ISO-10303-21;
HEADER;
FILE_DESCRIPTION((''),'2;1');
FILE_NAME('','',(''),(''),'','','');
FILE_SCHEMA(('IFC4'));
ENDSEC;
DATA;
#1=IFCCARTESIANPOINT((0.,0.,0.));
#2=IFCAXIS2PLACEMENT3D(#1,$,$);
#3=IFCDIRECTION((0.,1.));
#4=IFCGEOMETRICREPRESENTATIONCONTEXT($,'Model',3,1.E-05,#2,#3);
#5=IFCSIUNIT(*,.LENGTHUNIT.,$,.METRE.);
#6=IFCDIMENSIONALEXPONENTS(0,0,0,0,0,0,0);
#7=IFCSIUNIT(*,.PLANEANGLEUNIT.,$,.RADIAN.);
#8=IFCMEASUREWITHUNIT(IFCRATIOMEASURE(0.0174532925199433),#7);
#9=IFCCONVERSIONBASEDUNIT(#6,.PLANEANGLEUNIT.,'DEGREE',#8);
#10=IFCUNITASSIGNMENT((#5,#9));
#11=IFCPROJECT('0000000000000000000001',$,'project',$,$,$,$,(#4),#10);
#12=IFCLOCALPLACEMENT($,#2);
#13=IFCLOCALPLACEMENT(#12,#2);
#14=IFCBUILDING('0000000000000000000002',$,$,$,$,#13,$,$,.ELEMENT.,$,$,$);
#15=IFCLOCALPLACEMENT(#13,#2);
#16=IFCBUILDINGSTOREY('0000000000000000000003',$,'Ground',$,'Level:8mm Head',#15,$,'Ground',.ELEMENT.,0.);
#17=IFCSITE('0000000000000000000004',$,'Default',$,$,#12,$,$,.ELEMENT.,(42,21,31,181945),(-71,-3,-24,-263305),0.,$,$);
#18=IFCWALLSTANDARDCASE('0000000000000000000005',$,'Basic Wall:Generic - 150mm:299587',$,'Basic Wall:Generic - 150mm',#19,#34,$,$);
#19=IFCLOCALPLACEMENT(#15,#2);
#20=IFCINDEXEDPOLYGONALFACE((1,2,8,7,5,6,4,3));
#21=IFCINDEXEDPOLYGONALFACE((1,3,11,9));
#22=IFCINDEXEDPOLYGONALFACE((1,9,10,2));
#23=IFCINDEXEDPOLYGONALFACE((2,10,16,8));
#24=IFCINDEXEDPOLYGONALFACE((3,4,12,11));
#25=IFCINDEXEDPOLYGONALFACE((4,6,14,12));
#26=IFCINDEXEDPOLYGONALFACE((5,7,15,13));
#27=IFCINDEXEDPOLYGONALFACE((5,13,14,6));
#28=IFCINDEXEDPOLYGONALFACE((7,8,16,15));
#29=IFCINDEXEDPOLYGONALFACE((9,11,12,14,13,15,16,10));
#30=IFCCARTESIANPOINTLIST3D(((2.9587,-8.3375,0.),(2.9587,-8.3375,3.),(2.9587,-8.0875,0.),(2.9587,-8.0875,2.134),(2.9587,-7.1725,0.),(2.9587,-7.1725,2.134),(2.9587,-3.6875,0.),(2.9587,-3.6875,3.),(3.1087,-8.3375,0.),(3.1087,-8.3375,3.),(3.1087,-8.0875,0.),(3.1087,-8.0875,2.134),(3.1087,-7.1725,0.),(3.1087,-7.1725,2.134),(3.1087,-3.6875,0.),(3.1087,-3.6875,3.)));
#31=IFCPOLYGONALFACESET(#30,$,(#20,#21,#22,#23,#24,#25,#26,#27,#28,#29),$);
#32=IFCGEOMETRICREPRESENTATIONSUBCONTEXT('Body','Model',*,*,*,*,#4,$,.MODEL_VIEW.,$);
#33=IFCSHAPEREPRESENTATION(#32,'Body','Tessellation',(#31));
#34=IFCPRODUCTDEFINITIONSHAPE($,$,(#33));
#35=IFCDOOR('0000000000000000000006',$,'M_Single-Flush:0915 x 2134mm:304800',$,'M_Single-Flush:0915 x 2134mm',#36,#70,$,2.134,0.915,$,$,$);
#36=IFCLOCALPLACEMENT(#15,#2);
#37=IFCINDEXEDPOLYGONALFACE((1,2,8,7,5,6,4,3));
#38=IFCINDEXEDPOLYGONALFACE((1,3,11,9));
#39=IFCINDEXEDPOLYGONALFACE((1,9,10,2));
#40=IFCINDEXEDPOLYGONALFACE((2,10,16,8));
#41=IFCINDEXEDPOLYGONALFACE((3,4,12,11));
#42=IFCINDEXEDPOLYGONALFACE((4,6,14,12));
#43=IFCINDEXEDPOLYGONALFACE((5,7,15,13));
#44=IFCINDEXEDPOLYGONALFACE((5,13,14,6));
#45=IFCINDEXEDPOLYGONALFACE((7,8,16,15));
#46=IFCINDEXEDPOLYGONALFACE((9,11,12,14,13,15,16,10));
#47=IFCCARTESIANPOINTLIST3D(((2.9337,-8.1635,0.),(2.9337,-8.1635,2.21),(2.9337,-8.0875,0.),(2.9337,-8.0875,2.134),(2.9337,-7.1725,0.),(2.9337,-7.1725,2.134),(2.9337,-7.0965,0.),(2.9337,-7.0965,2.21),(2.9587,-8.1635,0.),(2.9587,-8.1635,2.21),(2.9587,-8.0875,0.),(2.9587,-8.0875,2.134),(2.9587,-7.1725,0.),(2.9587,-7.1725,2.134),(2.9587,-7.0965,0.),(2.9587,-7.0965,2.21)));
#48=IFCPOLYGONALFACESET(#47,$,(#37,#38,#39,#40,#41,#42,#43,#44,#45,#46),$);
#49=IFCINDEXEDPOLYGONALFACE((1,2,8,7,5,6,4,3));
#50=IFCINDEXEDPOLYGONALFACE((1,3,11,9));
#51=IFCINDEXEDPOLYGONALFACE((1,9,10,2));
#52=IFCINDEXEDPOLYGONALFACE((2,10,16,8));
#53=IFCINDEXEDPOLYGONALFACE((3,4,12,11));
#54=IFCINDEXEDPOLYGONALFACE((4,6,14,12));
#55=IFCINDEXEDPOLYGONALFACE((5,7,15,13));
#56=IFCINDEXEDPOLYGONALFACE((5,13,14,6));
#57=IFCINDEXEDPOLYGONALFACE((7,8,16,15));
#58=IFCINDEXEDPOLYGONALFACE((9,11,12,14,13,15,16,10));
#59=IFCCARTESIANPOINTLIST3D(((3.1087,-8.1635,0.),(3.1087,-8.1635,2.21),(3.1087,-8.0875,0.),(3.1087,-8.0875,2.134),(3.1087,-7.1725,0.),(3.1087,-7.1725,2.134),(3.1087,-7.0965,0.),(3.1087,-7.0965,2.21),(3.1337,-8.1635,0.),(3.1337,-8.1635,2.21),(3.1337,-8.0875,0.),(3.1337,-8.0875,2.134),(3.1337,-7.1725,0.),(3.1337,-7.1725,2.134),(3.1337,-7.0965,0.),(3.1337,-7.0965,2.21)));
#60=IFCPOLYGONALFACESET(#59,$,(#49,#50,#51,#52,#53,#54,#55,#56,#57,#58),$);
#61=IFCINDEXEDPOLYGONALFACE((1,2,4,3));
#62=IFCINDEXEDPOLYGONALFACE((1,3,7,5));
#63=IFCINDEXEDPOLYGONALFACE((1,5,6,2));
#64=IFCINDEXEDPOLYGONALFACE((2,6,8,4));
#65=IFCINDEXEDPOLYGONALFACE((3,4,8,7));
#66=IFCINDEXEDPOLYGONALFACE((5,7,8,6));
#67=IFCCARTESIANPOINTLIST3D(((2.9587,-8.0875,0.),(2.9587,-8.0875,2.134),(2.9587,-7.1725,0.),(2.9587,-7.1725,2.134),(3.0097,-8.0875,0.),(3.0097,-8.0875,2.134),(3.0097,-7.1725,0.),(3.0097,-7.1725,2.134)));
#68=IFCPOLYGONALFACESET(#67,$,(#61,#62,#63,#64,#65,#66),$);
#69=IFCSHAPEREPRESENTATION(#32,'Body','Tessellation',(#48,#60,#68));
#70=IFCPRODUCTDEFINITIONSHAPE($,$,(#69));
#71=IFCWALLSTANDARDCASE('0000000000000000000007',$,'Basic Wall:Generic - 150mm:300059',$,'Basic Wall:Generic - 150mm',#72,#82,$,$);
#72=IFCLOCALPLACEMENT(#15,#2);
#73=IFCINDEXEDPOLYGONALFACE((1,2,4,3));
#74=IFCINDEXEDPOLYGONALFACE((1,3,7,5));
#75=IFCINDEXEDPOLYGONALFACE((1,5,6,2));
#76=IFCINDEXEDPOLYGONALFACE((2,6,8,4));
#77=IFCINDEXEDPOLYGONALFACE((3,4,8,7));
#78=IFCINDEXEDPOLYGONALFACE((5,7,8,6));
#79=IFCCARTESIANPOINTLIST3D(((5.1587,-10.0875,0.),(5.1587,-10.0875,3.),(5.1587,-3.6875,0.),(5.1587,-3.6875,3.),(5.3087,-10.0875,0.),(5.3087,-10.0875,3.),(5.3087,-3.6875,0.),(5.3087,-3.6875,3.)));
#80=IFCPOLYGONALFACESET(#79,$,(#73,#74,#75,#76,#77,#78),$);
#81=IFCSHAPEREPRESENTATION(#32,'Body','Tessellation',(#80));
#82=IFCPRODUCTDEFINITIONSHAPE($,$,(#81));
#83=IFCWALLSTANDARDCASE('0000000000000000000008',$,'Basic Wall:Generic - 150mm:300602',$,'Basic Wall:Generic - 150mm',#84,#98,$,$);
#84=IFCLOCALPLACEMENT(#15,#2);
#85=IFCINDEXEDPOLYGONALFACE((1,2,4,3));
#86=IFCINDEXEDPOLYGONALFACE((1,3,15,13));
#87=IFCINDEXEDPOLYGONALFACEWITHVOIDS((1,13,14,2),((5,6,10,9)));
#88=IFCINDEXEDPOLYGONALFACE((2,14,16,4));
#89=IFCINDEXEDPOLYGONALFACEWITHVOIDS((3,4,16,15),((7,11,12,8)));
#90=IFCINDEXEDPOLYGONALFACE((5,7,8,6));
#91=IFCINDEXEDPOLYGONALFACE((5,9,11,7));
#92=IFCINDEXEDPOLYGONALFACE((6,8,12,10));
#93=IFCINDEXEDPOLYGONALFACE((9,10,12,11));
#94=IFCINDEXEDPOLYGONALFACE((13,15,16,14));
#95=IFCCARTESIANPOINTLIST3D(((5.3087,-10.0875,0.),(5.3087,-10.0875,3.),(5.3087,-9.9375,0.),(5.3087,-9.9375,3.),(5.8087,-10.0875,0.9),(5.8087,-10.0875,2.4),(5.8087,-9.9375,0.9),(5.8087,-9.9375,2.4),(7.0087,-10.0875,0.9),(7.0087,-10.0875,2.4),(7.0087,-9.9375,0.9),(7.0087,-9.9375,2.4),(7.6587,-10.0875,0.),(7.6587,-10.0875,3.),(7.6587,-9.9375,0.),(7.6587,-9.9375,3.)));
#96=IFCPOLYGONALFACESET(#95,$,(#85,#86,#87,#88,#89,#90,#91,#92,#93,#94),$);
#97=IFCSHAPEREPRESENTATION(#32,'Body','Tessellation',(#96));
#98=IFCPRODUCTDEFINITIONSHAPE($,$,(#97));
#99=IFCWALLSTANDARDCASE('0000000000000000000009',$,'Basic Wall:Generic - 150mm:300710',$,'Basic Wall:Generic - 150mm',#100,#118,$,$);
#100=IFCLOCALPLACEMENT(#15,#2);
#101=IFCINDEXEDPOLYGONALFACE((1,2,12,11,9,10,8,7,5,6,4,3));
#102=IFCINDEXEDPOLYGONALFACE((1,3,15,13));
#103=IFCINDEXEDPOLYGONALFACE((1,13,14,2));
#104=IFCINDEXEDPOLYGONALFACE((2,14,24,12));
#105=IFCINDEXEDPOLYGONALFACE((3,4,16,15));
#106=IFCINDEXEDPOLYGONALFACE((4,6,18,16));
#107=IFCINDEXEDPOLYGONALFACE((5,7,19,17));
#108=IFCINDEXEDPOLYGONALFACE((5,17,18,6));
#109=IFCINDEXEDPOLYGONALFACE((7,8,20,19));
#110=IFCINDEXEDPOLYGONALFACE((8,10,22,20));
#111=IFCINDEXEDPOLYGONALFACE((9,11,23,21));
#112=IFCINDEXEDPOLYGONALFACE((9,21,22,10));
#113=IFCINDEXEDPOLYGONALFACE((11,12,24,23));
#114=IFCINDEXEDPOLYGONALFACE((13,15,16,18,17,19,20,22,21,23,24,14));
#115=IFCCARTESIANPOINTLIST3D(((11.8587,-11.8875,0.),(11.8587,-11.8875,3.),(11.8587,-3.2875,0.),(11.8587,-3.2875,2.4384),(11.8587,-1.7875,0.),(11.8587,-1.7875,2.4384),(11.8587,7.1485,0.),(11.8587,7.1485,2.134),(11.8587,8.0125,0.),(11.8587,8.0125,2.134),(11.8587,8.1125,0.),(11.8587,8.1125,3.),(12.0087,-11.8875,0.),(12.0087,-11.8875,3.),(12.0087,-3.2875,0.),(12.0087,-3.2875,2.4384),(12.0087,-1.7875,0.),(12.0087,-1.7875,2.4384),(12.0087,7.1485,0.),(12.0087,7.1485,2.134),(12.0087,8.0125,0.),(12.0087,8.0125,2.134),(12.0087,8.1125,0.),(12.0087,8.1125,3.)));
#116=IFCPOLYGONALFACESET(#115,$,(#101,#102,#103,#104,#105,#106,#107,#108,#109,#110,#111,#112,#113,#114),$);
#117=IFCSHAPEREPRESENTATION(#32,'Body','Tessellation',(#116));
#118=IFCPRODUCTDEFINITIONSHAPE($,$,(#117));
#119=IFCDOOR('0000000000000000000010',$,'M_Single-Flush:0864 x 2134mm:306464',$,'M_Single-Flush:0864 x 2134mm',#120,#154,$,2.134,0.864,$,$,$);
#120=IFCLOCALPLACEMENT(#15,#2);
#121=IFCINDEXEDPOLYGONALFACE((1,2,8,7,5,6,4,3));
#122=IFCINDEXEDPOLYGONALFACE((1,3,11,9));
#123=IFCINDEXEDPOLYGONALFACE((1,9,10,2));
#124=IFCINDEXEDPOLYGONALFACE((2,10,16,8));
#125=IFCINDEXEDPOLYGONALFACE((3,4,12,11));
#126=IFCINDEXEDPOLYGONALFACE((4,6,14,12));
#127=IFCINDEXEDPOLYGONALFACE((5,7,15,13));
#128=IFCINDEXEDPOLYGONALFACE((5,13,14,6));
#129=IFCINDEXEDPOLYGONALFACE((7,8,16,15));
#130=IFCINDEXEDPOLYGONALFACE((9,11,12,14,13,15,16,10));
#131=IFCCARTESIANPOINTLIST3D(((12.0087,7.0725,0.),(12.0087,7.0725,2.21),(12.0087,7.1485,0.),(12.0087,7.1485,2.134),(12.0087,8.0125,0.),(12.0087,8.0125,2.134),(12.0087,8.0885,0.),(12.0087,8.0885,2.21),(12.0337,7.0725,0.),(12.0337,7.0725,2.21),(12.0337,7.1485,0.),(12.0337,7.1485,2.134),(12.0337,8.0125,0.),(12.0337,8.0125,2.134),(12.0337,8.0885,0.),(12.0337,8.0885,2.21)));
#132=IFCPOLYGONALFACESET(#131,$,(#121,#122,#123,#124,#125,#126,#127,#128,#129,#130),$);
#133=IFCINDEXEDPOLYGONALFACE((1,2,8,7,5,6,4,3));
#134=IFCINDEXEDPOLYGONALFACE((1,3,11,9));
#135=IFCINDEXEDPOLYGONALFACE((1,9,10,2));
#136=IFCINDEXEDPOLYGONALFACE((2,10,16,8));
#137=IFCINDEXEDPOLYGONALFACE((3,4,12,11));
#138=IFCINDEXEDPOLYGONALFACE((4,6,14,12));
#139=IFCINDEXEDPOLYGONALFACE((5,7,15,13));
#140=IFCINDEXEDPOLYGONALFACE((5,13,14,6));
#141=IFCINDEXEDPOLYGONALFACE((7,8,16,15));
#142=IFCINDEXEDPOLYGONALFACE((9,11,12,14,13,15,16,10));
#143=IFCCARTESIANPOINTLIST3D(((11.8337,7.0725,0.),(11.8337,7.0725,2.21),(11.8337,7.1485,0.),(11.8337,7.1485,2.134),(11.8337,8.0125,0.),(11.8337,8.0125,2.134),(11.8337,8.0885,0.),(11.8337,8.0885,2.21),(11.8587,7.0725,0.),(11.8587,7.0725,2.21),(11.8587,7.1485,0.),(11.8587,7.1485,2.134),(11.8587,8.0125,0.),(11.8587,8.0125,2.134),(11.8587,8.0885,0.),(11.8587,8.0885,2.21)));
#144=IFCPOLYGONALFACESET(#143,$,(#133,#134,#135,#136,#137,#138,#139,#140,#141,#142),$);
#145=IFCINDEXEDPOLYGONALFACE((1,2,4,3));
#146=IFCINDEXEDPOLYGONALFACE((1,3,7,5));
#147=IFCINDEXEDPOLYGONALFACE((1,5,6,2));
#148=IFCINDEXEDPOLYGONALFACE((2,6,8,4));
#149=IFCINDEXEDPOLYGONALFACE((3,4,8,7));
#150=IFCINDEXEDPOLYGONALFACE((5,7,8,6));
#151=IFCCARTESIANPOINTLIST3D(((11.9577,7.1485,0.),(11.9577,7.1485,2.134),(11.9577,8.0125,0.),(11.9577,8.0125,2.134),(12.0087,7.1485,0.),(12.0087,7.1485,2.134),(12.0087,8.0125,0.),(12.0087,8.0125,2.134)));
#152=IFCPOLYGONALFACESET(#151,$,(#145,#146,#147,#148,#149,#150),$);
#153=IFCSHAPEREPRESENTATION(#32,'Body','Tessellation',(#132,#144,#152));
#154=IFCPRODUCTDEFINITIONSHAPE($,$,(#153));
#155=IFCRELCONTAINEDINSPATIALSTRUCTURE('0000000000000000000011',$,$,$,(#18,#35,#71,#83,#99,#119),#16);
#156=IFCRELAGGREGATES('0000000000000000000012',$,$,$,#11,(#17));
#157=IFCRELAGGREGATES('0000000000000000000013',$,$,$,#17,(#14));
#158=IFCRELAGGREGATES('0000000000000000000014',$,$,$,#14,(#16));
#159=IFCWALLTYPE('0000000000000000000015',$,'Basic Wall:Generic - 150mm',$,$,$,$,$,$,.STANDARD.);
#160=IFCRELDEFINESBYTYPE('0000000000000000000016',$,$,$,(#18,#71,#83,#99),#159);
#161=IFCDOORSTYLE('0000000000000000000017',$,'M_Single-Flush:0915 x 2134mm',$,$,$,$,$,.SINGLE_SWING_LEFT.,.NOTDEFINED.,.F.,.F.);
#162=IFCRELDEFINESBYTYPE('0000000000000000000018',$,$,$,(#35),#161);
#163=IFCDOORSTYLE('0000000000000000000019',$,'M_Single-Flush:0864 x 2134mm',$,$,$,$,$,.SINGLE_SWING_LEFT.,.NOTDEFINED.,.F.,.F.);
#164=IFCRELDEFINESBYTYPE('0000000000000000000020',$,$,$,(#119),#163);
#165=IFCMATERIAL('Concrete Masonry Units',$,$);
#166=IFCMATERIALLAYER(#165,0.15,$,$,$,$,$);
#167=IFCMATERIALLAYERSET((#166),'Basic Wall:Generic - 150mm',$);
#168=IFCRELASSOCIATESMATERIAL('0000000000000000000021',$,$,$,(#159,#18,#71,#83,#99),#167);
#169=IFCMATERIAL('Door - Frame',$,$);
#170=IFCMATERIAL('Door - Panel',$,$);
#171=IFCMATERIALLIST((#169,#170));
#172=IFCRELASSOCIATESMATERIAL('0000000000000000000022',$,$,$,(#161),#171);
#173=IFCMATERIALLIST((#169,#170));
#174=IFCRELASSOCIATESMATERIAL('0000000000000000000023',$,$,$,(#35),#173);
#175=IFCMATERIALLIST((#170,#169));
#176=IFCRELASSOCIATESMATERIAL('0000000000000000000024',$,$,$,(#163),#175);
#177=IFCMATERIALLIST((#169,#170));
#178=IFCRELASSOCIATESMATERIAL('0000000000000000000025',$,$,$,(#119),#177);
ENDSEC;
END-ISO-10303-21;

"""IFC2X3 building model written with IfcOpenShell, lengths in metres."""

from ifc_helpers import new_model, entity, si_unit, converted_unit, direction, frame, frame_2d, origin, origin_2d_with_axis, place, context, subcontext, project, spatial, polyline, rectangle, outline, extrude, source, transform, mapped, material, material_list, layer, layer_set, layer_usage, type_object, type_shapes, element, fill, save


model = new_model("IFC2X3")

# Units and contexts
model_context = context("Model", 3, precision=1e-05, world=origin(), true_north=direction((0.0, 1.0)))
body_context = subcontext(model_context, "Body", "Model", "MODEL_VIEW")
ifc_project = project(units=[si_unit("LENGTHUNIT", "METRE"), converted_unit("PLANEANGLEUNIT", "DEGREE", entity("IfcRatioMeasure", 0.0174532925199433), si_unit("PLANEANGLEUNIT", "RADIAN"), dimensions=[0, 0, 0, 0, 0, 0, 0])], contexts=[model_context])

# Site, building, storey
site_placement = place(None, origin())
site = spatial("IfcSite", under=ifc_project, at=site_placement, Name="Default", CompositionType="ELEMENT", RefLatitude=(42, 21, 31, 181945), RefLongitude=(-71, -3, -24, -263305), RefElevation=0.0)
building_placement = place(site_placement, origin())
building = spatial("IfcBuilding", under=site, at=building_placement, CompositionType="ELEMENT")
storey_placement = place(building_placement, origin())
storey = spatial("IfcBuildingStorey", under=building, at=storey_placement, Name="Ground", ObjectType="Level:8mm Head", LongName="Ground", CompositionType="ELEMENT", Elevation=0.0)

# Shared definitions
ifc_material_1 = material(Name="Concrete Masonry Units")
ifc_layer = layer(ifc_material_1, 0.15)
ifc_layer_set = layer_set([ifc_layer], Name="Basic Wall:Generic - 150mm")
wall_type = type_object("IfcWallType", Name="Basic Wall:Generic - 150mm", PredefinedType="STANDARD", material=ifc_layer_set)
ifc_material_2 = material(Name="Door - Frame")
ifc_material_3 = material(Name="Door - Panel")

# Wall, opening, door
ifc_layer_usage_1 = layer_usage(ifc_layer_set, "AXIS2", "POSITIVE", -0.075)
wall_1_placement = place(storey_placement, frame((3.0337, -3.6875, 0.0), z_axis=(0.0, 0.0, 1.0), x_axis=(0.0, -1.0, 0.0)))
wall_1 = element("IfcWallStandardCase", 1, at=wall_1_placement, inside=storey, type_object=wall_type, material=ifc_layer_usage_1, Name="Basic Wall:Generic - 150mm:299587", ObjectType="Basic Wall:Generic - 150mm", context=body_context, shape_type="SweptSolid", body=[
    extrude(rectangle(XDim=4.65, YDim=0.15, at=frame_2d((2.325, 0.0), x_axis=(-1.0, 0.0))), origin(), (0.0, 0.0, 1.0), 3.0),
])
opening_1_placement = place(wall_1_placement, frame((4.4, 0.075, 0.0)))
opening_1 = element("IfcOpeningElement", 2, at=opening_1_placement, cuts=wall_1, ObjectType="Opening", context=body_context, shape_type="SweptSolid", body=[
    extrude(rectangle(XDim=0.915, YDim=2.134, at=frame_2d((1.067, 0.4575), x_axis=(0.0, -1.0))), frame((0.0, 0.0, 0.0), z_axis=(0.0, -1.0, 0.0), x_axis=(0.0, 0.0, 1.0)), (0.0, 0.0, 1.0), 0.15),
])
ifc_material_list_1 = material_list([ifc_material_2, ifc_material_3])
ifc_material_list_2 = material_list([ifc_material_2, ifc_material_3])
door_style_1 = type_object("IfcDoorStyle", Name="M_Single-Flush:0915 x 2134mm", ConstructionType="NOTDEFINED", OperationType="SINGLE_SWING_LEFT", ParameterTakesPrecedence=False, Sizeable=False, material=ifc_material_list_2)
shared_shape_1 = source(origin(), body_context, "Body", "SweptSolid", [
    extrude(outline(polyline([(-0.5335, -1.124), (0.5335, -1.124), (0.5335, 1.086), (0.4575, 1.086), (0.4575, -1.048), (-0.4575, -1.048), (-0.4575, 1.086), (-0.5335, 1.086), (-0.5335, -1.124)])), frame((0.4575, 0.175, 1.086), z_axis=(0.0, -1.0, 0.0), x_axis=(-1.0, 0.0, 0.0)), (0.0, 0.0, 1.0), 0.025),
    extrude(outline(polyline([(-1.124, -0.5335), (1.086, -0.5335), (1.086, -0.4575), (-1.048, -0.4575), (-1.048, 0.4575), (1.086, 0.4575), (1.086, 0.5335), (-1.124, 0.5335), (-1.124, -0.5335)])), frame((0.4575, 0.0, 1.086), z_axis=(0.0, -1.0, 0.0), x_axis=(0.0, 0.0, -1.0)), (0.0, 0.0, 1.0), 0.025),
    extrude(rectangle(XDim=0.915, YDim=0.051, at=frame_2d((0.0, 0.0), x_axis=(1.0, 0.0))), frame((0.4575, 0.1245, 0.0)), (0.0, 0.0, 1.0), 2.134),
])
type_shapes(door_style_1, [shared_shape_1])
door_1_placement = place(opening_1_placement, frame((0.0, 0.0, 0.0), z_axis=(0.0, 0.0, 1.0), x_axis=(-1.0, 0.0, 0.0)))
door_1 = element("IfcDoor", 3, at=door_1_placement, inside=storey, type_object=door_style_1, material=ifc_material_list_1, Name="M_Single-Flush:0915 x 2134mm:304800", ObjectType="M_Single-Flush:0915 x 2134mm", OverallHeight=2.134, OverallWidth=0.915, context=body_context, shape_type="MappedRepresentation", body=[
    mapped(shared_shape_1, transform((0.0, 0.0, 0.0), scale=1.0)),
])
fill(opening_1, door_1)

# Wall
ifc_layer_usage_2 = layer_usage(ifc_layer_set, "AXIS2", "POSITIVE", -0.075)
wall_2_placement = place(storey_placement, frame((5.2337, -3.6875, 0.0), z_axis=(0.0, 0.0, 1.0), x_axis=(0.0, -1.0, 0.0)))
element("IfcWallStandardCase", 4, at=wall_2_placement, inside=storey, type_object=wall_type, material=ifc_layer_usage_2, Name="Basic Wall:Generic - 150mm:300059", ObjectType="Basic Wall:Generic - 150mm", context=body_context, shape_type="SweptSolid", body=[
    extrude(rectangle(XDim=6.4, YDim=0.15, at=frame_2d((3.2, 0.0), x_axis=(-1.0, 0.0))), origin(), (0.0, 0.0, 1.0), 3.0),
])

# Wall, opening
ifc_layer_usage_3 = layer_usage(ifc_layer_set, "AXIS2", "POSITIVE", -0.075)
wall_3_placement = place(storey_placement, frame((5.3087, -10.0125, 0.0)))
wall_3 = element("IfcWallStandardCase", 5, at=wall_3_placement, inside=storey, type_object=wall_type, material=ifc_layer_usage_3, Name="Basic Wall:Generic - 150mm:300602", ObjectType="Basic Wall:Generic - 150mm", context=body_context, shape_type="SweptSolid", body=[
    extrude(rectangle(XDim=2.35, YDim=0.15, at=frame_2d((1.175, 0.0), x_axis=(-1.0, 0.0))), origin(), (0.0, 0.0, 1.0), 3.0),
])
opening_2_placement = place(wall_3_placement, frame((0.5, -0.075, 0.9)))
element("IfcOpeningElement", 6, at=opening_2_placement, cuts=wall_3, ObjectType="Opening", context=body_context, shape_type="SweptSolid", body=[
    extrude(rectangle(XDim=1.5, YDim=1.2, at=frame_2d((0.75, 0.6), x_axis=(-1.0, 0.0))), frame((0.0, 0.0, 0.0), z_axis=(0.0, 1.0, 0.0), x_axis=(0.0, 0.0, 1.0)), (0.0, 0.0, 1.0), 0.15),
])

# Wall, openings, door
ifc_layer_usage_4 = layer_usage(ifc_layer_set, "AXIS2", "NEGATIVE", 0.075)
wall_4_placement = place(storey_placement, frame((11.9337, -11.8875, 0.0), z_axis=(0.0, 0.0, 1.0), x_axis=(0.0, 1.0, 0.0)))
wall_4 = element("IfcWallStandardCase", 7, at=wall_4_placement, inside=storey, type_object=wall_type, material=ifc_layer_usage_4, Name="Basic Wall:Generic - 150mm:300710", ObjectType="Basic Wall:Generic - 150mm", context=body_context, shape_type="SweptSolid", body=[
    extrude(rectangle(XDim=20.0, YDim=0.15, at=frame_2d((10.0, 0.0), x_axis=(-1.0, 0.0))), origin(), (0.0, 0.0, 1.0), 3.0),
])
opening_3_placement = place(wall_4_placement, origin())
element("IfcOpeningElement", 8, at=opening_3_placement, cuts=wall_4, ObjectType="Opening", context=body_context, shape_type="SweptSolid", body=[
    extrude(rectangle(XDim=2.4384, YDim=1.5, at=origin_2d_with_axis()), frame((9.35, -0.075, 1.2192), z_axis=(0.0, 1.0, 0.0), x_axis=(0.0, 0.0, -1.0)), (0.0, 0.0, 1.0), 0.15),
])
opening_4_placement = place(wall_4_placement, frame((19.9, 0.075, 0.0)))
opening_4 = element("IfcOpeningElement", 9, at=opening_4_placement, cuts=wall_4, ObjectType="Opening", context=body_context, shape_type="SweptSolid", body=[
    extrude(rectangle(XDim=0.864, YDim=2.134, at=frame_2d((1.067, 0.432), x_axis=(0.0, -1.0))), frame((0.0, 0.0, 0.0), z_axis=(0.0, -1.0, 0.0), x_axis=(0.0, 0.0, 1.0)), (0.0, 0.0, 1.0), 0.15),
])
ifc_material_list_3 = material_list([ifc_material_2, ifc_material_3])
ifc_material_list_4 = material_list([ifc_material_3, ifc_material_2])
door_style_2 = type_object("IfcDoorStyle", Name="M_Single-Flush:0864 x 2134mm", ConstructionType="NOTDEFINED", OperationType="SINGLE_SWING_LEFT", ParameterTakesPrecedence=False, Sizeable=False, material=ifc_material_list_4)
shared_shape_2 = source(origin(), body_context, "Body", "SweptSolid", [
    extrude(outline(polyline([(-0.508, -1.124), (0.508, -1.124), (0.508, 1.086), (0.432, 1.086), (0.432, -1.048), (-0.432, -1.048), (-0.432, 1.086), (-0.508, 1.086), (-0.508, -1.124)])), frame((0.432, 0.175, 1.086), z_axis=(0.0, -1.0, 0.0), x_axis=(-1.0, 0.0, 0.0)), (0.0, 0.0, 1.0), 0.025),
    extrude(outline(polyline([(-1.124, -0.508), (1.086, -0.508), (1.086, -0.432), (-1.048, -0.432), (-1.048, 0.432), (1.086, 0.432), (1.086, 0.508), (-1.124, 0.508), (-1.124, -0.508)])), frame((0.432, 0.0, 1.086), z_axis=(0.0, -1.0, 0.0), x_axis=(0.0, 0.0, -1.0)), (0.0, 0.0, 1.0), 0.025),
    extrude(rectangle(XDim=0.864, YDim=0.051, at=frame_2d((0.0, 0.0), x_axis=(1.0, 0.0))), frame((0.432, 0.1245, 0.0)), (0.0, 0.0, 1.0), 2.134),
])
type_shapes(door_style_2, [shared_shape_2])
door_2_placement = place(opening_4_placement, frame((0.0, 0.0, 0.0), z_axis=(0.0, 0.0, 1.0), x_axis=(-1.0, 0.0, 0.0)))
door_2 = element("IfcDoor", 10, at=door_2_placement, inside=storey, type_object=door_style_2, material=ifc_material_list_3, Name="M_Single-Flush:0864 x 2134mm:306464", ObjectType="M_Single-Flush:0864 x 2134mm", OverallHeight=2.134, OverallWidth=0.864, context=body_context, shape_type="MappedRepresentation", body=[
    mapped(shared_shape_2, transform((0.0, 0.0, 0.0), scale=1.0)),
])
fill(opening_4, door_2)

save(model, "model.ifc")
